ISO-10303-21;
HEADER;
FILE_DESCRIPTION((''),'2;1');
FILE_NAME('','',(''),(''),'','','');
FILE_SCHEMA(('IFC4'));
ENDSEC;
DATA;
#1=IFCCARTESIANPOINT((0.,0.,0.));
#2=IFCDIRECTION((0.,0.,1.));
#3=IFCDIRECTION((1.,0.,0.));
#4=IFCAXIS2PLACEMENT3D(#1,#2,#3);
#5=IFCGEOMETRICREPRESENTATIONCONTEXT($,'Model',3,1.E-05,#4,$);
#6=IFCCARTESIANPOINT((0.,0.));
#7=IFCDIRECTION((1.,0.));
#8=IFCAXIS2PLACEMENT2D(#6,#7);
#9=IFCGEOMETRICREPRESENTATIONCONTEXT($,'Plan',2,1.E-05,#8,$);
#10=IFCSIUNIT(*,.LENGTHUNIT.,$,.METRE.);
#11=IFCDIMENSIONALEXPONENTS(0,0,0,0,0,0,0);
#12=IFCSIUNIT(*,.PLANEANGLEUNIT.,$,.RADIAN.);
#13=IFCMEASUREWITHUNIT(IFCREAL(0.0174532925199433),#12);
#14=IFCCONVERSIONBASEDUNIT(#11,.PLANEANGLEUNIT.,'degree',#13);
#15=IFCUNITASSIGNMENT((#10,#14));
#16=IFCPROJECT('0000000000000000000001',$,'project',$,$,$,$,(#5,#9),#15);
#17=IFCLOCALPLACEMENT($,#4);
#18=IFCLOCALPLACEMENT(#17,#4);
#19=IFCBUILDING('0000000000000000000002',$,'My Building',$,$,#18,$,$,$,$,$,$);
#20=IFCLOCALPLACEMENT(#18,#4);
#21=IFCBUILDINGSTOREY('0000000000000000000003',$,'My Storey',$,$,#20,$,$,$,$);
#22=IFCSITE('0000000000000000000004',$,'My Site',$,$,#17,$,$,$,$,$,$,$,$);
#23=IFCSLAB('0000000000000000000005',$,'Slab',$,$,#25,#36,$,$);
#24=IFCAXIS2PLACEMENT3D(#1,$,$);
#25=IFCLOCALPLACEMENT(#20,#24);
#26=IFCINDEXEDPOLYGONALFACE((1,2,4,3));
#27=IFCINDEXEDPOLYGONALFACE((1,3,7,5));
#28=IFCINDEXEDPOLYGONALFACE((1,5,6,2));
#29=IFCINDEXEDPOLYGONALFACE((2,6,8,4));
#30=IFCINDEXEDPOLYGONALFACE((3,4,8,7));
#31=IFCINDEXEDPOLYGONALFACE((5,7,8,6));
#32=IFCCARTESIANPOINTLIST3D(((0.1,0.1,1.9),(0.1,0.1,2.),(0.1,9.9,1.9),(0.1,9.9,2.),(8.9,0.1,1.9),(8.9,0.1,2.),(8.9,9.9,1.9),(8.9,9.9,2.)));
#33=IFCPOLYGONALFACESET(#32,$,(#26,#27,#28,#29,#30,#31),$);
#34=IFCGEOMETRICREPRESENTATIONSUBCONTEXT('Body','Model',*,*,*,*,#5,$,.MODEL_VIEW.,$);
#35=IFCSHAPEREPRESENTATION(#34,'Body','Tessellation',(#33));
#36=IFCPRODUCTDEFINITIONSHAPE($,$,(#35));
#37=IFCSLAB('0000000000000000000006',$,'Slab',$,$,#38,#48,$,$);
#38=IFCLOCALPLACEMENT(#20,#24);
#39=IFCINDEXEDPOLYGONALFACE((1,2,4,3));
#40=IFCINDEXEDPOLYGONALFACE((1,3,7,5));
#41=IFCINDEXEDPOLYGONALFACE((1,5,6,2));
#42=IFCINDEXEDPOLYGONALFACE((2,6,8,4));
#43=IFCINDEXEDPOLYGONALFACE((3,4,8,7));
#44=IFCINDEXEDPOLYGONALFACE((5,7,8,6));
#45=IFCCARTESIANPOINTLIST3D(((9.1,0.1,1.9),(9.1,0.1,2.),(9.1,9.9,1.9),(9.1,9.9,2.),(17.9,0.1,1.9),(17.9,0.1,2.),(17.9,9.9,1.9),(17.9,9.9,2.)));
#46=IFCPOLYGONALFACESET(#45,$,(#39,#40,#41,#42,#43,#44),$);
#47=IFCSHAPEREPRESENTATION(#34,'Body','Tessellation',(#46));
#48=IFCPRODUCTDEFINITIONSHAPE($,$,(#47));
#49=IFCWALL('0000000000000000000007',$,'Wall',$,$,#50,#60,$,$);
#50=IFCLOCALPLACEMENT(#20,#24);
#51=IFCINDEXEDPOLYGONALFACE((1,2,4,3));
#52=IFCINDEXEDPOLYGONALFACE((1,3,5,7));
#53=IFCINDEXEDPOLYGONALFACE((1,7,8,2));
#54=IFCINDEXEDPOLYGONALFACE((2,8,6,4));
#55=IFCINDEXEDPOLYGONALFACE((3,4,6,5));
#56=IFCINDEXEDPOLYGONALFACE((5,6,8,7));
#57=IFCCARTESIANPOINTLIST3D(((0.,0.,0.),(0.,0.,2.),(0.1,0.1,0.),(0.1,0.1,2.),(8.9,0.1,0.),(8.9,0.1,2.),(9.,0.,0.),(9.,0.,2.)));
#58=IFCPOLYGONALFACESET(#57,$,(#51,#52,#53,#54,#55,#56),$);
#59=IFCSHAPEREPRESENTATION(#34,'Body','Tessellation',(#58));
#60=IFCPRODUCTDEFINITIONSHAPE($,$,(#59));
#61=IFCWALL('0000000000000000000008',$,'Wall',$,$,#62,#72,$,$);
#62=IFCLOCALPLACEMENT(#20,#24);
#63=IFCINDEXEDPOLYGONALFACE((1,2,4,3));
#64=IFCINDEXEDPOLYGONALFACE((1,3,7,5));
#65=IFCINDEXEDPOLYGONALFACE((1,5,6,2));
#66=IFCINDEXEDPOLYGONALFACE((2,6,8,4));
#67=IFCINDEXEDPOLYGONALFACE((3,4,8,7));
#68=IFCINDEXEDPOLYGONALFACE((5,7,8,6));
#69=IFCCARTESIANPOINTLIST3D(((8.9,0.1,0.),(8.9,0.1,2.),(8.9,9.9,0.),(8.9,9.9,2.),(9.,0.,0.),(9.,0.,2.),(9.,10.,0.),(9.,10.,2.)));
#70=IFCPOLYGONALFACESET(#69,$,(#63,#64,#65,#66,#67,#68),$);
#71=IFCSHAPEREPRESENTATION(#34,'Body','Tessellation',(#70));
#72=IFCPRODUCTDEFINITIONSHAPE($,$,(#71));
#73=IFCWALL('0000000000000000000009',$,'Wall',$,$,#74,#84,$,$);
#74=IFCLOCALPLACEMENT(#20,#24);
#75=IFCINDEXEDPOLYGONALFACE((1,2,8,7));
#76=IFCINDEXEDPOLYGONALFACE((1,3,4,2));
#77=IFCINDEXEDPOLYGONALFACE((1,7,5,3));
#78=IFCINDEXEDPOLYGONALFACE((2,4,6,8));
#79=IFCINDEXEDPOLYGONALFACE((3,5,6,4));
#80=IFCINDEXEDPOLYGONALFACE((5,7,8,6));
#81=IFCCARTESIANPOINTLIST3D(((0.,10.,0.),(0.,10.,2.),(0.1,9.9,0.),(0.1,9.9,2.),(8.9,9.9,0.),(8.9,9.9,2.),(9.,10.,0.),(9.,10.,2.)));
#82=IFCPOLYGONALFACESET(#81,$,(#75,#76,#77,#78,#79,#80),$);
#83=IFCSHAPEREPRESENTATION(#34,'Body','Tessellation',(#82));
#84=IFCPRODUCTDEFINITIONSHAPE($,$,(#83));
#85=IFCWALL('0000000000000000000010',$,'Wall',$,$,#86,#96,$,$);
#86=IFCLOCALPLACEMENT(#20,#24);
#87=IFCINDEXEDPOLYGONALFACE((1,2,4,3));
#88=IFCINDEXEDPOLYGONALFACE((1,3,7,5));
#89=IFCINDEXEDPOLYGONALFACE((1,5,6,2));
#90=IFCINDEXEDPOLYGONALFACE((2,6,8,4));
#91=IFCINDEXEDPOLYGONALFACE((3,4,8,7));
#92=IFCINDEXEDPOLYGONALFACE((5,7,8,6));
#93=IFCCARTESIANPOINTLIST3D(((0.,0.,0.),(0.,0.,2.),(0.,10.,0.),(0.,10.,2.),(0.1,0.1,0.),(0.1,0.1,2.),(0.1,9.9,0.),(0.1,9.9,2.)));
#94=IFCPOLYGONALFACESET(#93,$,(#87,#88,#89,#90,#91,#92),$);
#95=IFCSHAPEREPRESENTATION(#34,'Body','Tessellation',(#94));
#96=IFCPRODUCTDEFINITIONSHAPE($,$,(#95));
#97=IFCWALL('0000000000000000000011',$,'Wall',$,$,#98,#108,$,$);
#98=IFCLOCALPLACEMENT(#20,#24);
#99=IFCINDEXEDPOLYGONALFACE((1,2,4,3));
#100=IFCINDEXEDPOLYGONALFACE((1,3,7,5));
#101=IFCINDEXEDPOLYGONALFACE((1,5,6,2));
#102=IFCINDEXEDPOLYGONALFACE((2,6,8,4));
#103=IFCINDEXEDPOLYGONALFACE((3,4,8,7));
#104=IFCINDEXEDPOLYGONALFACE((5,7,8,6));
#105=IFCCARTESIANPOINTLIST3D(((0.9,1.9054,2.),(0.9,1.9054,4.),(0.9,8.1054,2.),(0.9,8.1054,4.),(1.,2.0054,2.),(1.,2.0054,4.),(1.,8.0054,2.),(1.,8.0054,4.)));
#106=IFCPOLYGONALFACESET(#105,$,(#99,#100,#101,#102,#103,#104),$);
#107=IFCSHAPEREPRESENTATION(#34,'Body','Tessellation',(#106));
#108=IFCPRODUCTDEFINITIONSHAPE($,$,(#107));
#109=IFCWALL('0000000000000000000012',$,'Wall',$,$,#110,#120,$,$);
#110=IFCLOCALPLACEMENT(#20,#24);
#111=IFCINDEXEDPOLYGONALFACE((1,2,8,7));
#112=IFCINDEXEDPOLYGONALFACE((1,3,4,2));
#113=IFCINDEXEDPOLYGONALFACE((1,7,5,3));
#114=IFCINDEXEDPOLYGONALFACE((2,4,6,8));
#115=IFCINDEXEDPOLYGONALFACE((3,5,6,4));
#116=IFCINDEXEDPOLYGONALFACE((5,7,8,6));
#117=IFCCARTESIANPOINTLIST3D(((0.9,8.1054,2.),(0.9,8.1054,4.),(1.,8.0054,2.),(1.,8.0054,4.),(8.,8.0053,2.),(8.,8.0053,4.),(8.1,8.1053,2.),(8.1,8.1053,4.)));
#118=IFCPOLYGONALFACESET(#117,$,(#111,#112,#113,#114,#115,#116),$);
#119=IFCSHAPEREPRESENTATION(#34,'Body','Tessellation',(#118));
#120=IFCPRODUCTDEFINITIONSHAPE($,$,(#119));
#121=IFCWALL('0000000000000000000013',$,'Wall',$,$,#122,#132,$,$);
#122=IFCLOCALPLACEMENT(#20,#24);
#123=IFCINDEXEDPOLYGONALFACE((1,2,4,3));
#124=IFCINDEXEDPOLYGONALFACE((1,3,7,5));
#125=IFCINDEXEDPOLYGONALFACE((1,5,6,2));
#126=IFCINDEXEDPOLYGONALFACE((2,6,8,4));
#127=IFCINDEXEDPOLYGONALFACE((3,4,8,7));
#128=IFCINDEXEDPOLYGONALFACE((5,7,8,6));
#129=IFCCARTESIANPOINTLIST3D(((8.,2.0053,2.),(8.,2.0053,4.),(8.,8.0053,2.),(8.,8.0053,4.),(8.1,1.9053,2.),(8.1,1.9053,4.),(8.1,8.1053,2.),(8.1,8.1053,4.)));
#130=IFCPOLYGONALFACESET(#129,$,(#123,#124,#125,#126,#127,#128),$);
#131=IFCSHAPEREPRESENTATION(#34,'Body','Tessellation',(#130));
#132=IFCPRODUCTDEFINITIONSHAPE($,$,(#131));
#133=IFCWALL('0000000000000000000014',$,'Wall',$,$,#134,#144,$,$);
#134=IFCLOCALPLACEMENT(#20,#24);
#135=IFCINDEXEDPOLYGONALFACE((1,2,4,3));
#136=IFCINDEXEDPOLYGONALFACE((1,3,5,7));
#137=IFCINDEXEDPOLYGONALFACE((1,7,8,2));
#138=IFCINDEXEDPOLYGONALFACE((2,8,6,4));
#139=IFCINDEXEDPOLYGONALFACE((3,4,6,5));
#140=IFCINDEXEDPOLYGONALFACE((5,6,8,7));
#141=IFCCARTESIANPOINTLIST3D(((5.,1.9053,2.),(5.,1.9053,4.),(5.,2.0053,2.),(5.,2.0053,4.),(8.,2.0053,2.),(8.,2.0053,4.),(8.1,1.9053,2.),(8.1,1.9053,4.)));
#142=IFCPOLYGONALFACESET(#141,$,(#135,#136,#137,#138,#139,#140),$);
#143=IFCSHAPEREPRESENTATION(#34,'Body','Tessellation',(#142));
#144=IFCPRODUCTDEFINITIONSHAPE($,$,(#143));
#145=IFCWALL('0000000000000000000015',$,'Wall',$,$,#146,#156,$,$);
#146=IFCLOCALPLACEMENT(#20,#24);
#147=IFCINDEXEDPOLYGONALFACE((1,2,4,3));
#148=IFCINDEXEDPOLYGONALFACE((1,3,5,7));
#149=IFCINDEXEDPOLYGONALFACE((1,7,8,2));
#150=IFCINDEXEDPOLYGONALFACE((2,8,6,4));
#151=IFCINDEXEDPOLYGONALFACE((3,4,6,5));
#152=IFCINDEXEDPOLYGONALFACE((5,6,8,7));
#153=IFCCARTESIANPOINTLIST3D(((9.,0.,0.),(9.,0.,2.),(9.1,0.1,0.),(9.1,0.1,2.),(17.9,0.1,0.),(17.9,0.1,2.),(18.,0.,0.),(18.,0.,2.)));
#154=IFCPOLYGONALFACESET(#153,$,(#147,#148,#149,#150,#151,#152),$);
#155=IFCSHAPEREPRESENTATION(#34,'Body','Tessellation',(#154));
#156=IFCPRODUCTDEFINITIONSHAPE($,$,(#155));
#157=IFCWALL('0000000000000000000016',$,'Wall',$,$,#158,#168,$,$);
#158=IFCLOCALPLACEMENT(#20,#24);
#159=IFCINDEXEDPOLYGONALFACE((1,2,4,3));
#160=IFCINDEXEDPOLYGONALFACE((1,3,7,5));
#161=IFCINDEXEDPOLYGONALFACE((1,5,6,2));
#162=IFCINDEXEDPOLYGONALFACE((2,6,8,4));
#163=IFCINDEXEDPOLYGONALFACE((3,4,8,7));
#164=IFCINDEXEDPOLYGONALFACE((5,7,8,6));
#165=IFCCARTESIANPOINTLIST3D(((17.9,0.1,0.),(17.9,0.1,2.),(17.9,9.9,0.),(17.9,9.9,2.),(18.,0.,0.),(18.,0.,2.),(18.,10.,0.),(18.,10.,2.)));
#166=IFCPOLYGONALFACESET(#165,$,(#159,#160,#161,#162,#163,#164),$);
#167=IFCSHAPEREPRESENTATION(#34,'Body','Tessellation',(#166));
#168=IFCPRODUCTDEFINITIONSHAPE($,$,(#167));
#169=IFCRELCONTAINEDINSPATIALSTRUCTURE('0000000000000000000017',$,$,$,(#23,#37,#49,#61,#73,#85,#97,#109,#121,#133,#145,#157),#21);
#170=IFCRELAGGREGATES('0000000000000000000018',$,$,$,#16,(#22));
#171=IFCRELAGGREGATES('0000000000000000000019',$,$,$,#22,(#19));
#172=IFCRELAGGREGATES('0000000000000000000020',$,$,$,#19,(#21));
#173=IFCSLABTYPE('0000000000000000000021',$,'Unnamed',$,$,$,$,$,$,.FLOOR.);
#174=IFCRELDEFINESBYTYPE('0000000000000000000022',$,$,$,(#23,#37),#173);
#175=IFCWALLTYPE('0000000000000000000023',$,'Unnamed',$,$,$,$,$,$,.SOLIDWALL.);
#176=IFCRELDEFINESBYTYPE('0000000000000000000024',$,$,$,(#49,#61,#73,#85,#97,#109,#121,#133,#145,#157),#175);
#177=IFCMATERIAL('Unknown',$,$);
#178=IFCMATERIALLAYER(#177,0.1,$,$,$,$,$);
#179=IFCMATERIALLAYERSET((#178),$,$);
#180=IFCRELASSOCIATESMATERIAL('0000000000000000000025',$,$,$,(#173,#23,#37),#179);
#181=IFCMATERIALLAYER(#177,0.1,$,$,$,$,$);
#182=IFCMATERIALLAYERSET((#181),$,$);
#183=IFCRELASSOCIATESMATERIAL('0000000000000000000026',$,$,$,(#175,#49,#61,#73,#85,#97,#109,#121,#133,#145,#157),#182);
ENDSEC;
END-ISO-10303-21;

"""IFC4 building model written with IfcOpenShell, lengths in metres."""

from ifc_helpers import new_model, entity, si_unit, converted_unit, frame, origin_with_axes, origin_2d_with_axis, place, context, subcontext, project, spatial, indexed_curve, outline, extrude, clip, halfspace, material, layer, layer_set, layer_usage, type_object, element, save


model = new_model("IFC4")

# Units and contexts
model_context = context("Model", 3, precision=1e-05, world=origin_with_axes())
plan_context = context("Plan", 2, precision=1e-05, world=origin_2d_with_axis())
body_context_1 = subcontext(model_context, "Body", "Model", "MODEL_VIEW")
ifc_project = project(units=[si_unit("LENGTHUNIT", "METRE"), converted_unit("PLANEANGLEUNIT", "degree", entity("IfcReal", 0.0174532925199433), si_unit("PLANEANGLEUNIT", "RADIAN"), dimensions=[0, 0, 0, 0, 0, 0, 0])], contexts=[model_context, plan_context])

# Site, building, storey
site_placement = place(None, origin_with_axes())
site = spatial("IfcSite", under=ifc_project, at=site_placement, Name="My Site")
building_placement = place(site_placement, origin_with_axes())
building = spatial("IfcBuilding", under=site, at=building_placement, Name="My Building")
storey_placement = place(building_placement, origin_with_axes())
storey = spatial("IfcBuildingStorey", under=building, at=storey_placement, Name="My Storey")

# Slabs
ifc_material = material(Name="Unknown")
ifc_layer_1 = layer(ifc_material, 0.1)
ifc_layer_set_1 = layer_set([ifc_layer_1])
ifc_layer_usage_1 = layer_usage(ifc_layer_set_1, "AXIS3", "POSITIVE", -0.1)
slab_type = type_object("IfcSlabType", Name="Unnamed", PredefinedType="FLOOR", material=ifc_layer_set_1)
slab_1_placement = place(storey_placement, frame((0.1, 9.9, 2.0), z_axis=(0.0, 0.0, 1.0), x_axis=(1.0, 0.0, 0.0)))
element("IfcSlab", 1, at=slab_1_placement, inside=storey, type_object=slab_type, material=ifc_layer_usage_1, Name="Slab", context=body_context_1, shape_type="SweptSolid", body=[
    extrude(outline(indexed_curve([(0.0, 0.0), (8.8, 0.0), (8.8, -9.8), (0.0, -9.8), (0.0, 0.0)])), frame((0.0, 0.0, -0.1), z_axis=(0.0, 0.0, 1.0), x_axis=(1.0, 0.0, 0.0)), (0.0, 0.0, 1.0), 0.1),
])
ifc_layer_usage_2 = layer_usage(ifc_layer_set_1, "AXIS3", "POSITIVE", -0.1)
slab_2_placement = place(storey_placement, frame((9.1, 0.1, 2.0), z_axis=(0.0, 0.0, 1.0), x_axis=(1.0, 0.0, 0.0)))
element("IfcSlab", 2, at=slab_2_placement, inside=storey, type_object=slab_type, material=ifc_layer_usage_2, Name="Slab", context=body_context_1, shape_type="SweptSolid", body=[
    extrude(outline(indexed_curve([(0.0, 0.0), (8.8, 0.0), (8.8, 9.8), (0.0, 9.8), (0.0, 0.0)])), frame((0.0, 0.0, -0.1), z_axis=(0.0, 0.0, 1.0), x_axis=(1.0, 0.0, 0.0)), (0.0, 0.0, 1.0), 0.1),
])

# Walls
ifc_layer_2 = layer(ifc_material, 0.1)
ifc_layer_set_2 = layer_set([ifc_layer_2])
ifc_layer_usage_3 = layer_usage(ifc_layer_set_2, "AXIS2", "POSITIVE", 0.0)
wall_type = type_object("IfcWallType", Name="Unnamed", PredefinedType="SOLIDWALL", material=ifc_layer_set_2)
wall_1_placement = place(storey_placement, origin_with_axes())
element("IfcWall", 3, at=wall_1_placement, inside=storey, type_object=wall_type, material=ifc_layer_usage_3, Name="Wall", context=body_context_1, shape_type="Clipping", body=[
    clip(clip(extrude(outline(indexed_curve([(0.0, 0.0), (0.0, 0.1), (9.0, 0.1), (9.0, 0.0), (0.0, 0.0)], self_intersect=False)), origin_with_axes(), (0.0, 0.0, 1.0), 2.0), halfspace(frame((9.0, 0.0, 0.0), z_axis=(0.707105, 0.707108, 0.0), x_axis=(0.707108, -0.707105, 0.0)), False)), halfspace(frame((0.0, 0.0, 0.0), z_axis=(-0.707107, 0.707107, 0.0), x_axis=(0.707107, 0.707107, 0.0)), False)),
])
ifc_layer_usage_4 = layer_usage(ifc_layer_set_2, "AXIS2", "POSITIVE", 0.0)
wall_2_placement = place(storey_placement, frame((9.0, 0.0, 0.0), z_axis=(0.0, 0.0, 1.0), x_axis=(0.0, 1.0, 0.0)))
element("IfcWall", 4, at=wall_2_placement, inside=storey, type_object=wall_type, material=ifc_layer_usage_4, Name="Wall", context=body_context_1, shape_type="Clipping", body=[
    clip(clip(extrude(outline(indexed_curve([(0.0, 0.0), (0.0, 0.1), (10.0, 0.1), (10.0, 0.0), (0.0, 0.0)], self_intersect=False)), origin_with_axes(), (0.0, 0.0, 1.0), 2.0), halfspace(frame((10.0, 0.0, 0.0), z_axis=(0.707107, 0.707107, 0.0), x_axis=(0.707107, -0.707107, 0.0)), False)), halfspace(frame((0.0, 0.0, 0.0), z_axis=(-0.707108, 0.707105, 0.0), x_axis=(0.707105, 0.707108, 0.0)), False)),
])
ifc_layer_usage_5 = layer_usage(ifc_layer_set_2, "AXIS2", "POSITIVE", 0.0)
wall_3_placement = place(storey_placement, frame((9.0, 10.0, 0.0), z_axis=(0.0, 0.0, 1.0), x_axis=(-1.0, 0.0, 0.0)))
element("IfcWall", 5, at=wall_3_placement, inside=storey, type_object=wall_type, material=ifc_layer_usage_5, Name="Wall", context=body_context_1, shape_type="Clipping", body=[
    clip(clip(extrude(outline(indexed_curve([(0.0, 0.0), (0.0, 0.1), (9.0, 0.1), (9.0, 0.0), (0.0, 0.0)], self_intersect=False)), origin_with_axes(), (0.0, 0.0, 1.0), 2.0), halfspace(frame((9.0, 0.0, 0.0), z_axis=(0.707108, 0.707106, 0.0), x_axis=(0.707106, -0.707108, 0.0)), False)), halfspace(frame((0.0, 0.0, 0.0), z_axis=(-0.707107, 0.707107, 0.0), x_axis=(0.707107, 0.707107, 0.0)), False)),
])
ifc_layer_usage_6 = layer_usage(ifc_layer_set_2, "AXIS2", "POSITIVE", 0.0)
wall_4_placement = place(storey_placement, frame((0.0, 10.0, 0.0), z_axis=(0.0, 0.0, 1.0), x_axis=(0.0, -1.0, 0.0)))
element("IfcWall", 6, at=wall_4_placement, inside=storey, type_object=wall_type, material=ifc_layer_usage_6, Name="Wall", context=body_context_1, shape_type="Clipping", body=[
    clip(clip(extrude(outline(indexed_curve([(0.0, 0.0), (0.0, 0.1), (10.0, 0.1), (10.0, 0.0), (0.0, 0.0)], self_intersect=False)), origin_with_axes(), (0.0, 0.0, 1.0), 2.0), halfspace(frame((10.0, 0.0, 0.0), z_axis=(0.707107, 0.707107, 0.0), x_axis=(0.707107, -0.707107, 0.0)), False)), halfspace(frame((0.0, 0.0, 0.0), z_axis=(-0.707105, 0.707108, 0.0), x_axis=(0.707108, 0.707105, 0.0)), False)),
])
ifc_layer_usage_7 = layer_usage(ifc_layer_set_2, "AXIS2", "POSITIVE", 0.0)
wall_5_placement = place(storey_placement, frame((1.0, 1.9054, 2.0), z_axis=(0.0, 0.0, 1.0), x_axis=(0.0, 1.0, 0.0)))
element("IfcWall", 7, at=wall_5_placement, inside=storey, type_object=wall_type, material=ifc_layer_usage_7, Name="Wall", context=body_context_1, shape_type="Clipping", body=[
    clip(clip(extrude(outline(indexed_curve([(0.0, 0.0), (0.0, 0.1), (6.2, 0.1), (6.2, 0.0), (0.0, 0.0)], self_intersect=False)), origin_with_axes(), (0.0, 0.0, 1.0), 2.0), halfspace(frame((6.1, 0.0, 0.0), z_axis=(0.707107, -0.707107, 0.0), x_axis=(-0.707107, -0.707107, 0.0)), False)), halfspace(frame((0.1, 0.0, 0.0), z_axis=(-0.707107, -0.707106, 0.0), x_axis=(-0.707106, 0.707107, 0.0)), False)),
])
ifc_layer_usage_8 = layer_usage(ifc_layer_set_2, "AXIS2", "POSITIVE", 0.0)
wall_6_placement = place(storey_placement, frame((0.9, 8.0054, 2.0), z_axis=(0.0, 0.0, 1.0), x_axis=(1.0, 0.0, 0.0)))
element("IfcWall", 8, at=wall_6_placement, inside=storey, type_object=wall_type, material=ifc_layer_usage_8, Name="Wall", context=body_context_1, shape_type="Clipping", body=[
    clip(clip(extrude(outline(indexed_curve([(0.0, 0.0), (0.0, 0.1), (7.2, 0.1), (7.2, 0.0), (0.0, 0.0)], self_intersect=False)), origin_with_axes(), (0.0, 0.0, 1.0), 2.0), halfspace(frame((7.1, 0.0, 0.0), z_axis=(0.707102, -0.707111, 0.0), x_axis=(-0.707111, -0.707102, 0.0)), False)), halfspace(frame((0.1, 0.0, 0.0), z_axis=(-0.707107, -0.707107, 0.0), x_axis=(-0.707107, 0.707107, 0.0)), False)),
])
ifc_layer_usage_9 = layer_usage(ifc_layer_set_2, "AXIS2", "POSITIVE", 0.0)
wall_7_placement = place(storey_placement, frame((8.0, 8.1053, 2.0), z_axis=(0.0, 0.0, 1.0), x_axis=(0.0, -1.0, 0.0)))
element("IfcWall", 9, at=wall_7_placement, inside=storey, type_object=wall_type, material=ifc_layer_usage_9, Name="Wall", context=body_context_1, shape_type="Clipping", body=[
    clip(clip(extrude(outline(indexed_curve([(0.0, 0.0), (0.0, 0.1), (6.2, 0.1), (6.2, 0.0), (0.0, 0.0)], self_intersect=False)), origin_with_axes(), (0.0, 0.0, 1.0), 2.0), halfspace(frame((6.1, 0.0, 0.0), z_axis=(0.70711, -0.707103, 0.0), x_axis=(-0.707103, -0.70711, 0.0)), False)), halfspace(frame((0.1, 0.0, 0.0), z_axis=(-0.707108, -0.707105, 0.0), x_axis=(-0.707105, 0.707108, 0.0)), False)),
])
ifc_layer_usage_10 = layer_usage(ifc_layer_set_2, "AXIS2", "POSITIVE", 0.0)
wall_8_placement = place(storey_placement, frame((8.1, 2.0053, 2.0), z_axis=(0.0, 0.0, 1.0), x_axis=(-1.0, 0.0, 0.0)))
element("IfcWall", 10, at=wall_8_placement, inside=storey, type_object=wall_type, material=ifc_layer_usage_10, Name="Wall", context=body_context_1, shape_type="Clipping", body=[
    clip(extrude(outline(indexed_curve([(0.0, 0.0), (0.0, 0.1), (3.1, 0.1), (3.1, 0.0), (0.0, 0.0)], self_intersect=False)), origin_with_axes(), (0.0, 0.0, 1.0), 2.0), halfspace(frame((0.1, 0.0, 0.0), z_axis=(-0.707103, -0.70711, 0.0), x_axis=(-0.70711, 0.707103, 0.0)), False)),
])
ifc_layer_usage_11 = layer_usage(ifc_layer_set_2, "AXIS2", "POSITIVE", 0.0)
wall_9_placement = place(storey_placement, frame((9.0, 0.0, 0.0), z_axis=(0.0, 0.0, 1.0), x_axis=(1.0, 0.0, 0.0)))
element("IfcWall", 11, at=wall_9_placement, inside=storey, type_object=wall_type, material=ifc_layer_usage_11, Name="Wall", context=body_context_1, shape_type="Clipping", body=[
    clip(clip(extrude(outline(indexed_curve([(0.0, 0.0), (0.0, 0.1), (9.0, 0.1), (9.0, 0.0), (0.0, 0.0)], self_intersect=False)), origin_with_axes(), (0.0, 0.0, 1.0), 2.0), halfspace(frame((9.0, 0.0, 0.0), z_axis=(0.707105, 0.707108, 0.0), x_axis=(0.707108, -0.707105, 0.0)), False)), halfspace(frame((0.0, 0.0, 0.0), z_axis=(-0.707105, 0.707108, 0.0), x_axis=(0.707108, 0.707105, 0.0)), False)),
])
ifc_layer_usage_12 = layer_usage(ifc_layer_set_2, "AXIS2", "POSITIVE", 0.0)
wall_10_placement = place(storey_placement, frame((18.0, 0.0, 0.0), z_axis=(0.0, 0.0, 1.0), x_axis=(0.0, 1.0, 0.0)))
element("IfcWall", 12, at=wall_10_placement, inside=storey, type_object=wall_type, material=ifc_layer_usage_12, Name="Wall", context=body_context_1, shape_type="Clipping", body=[
    clip(clip(extrude(outline(indexed_curve([(0.0, 0.0), (0.0, 0.1), (10.0, 0.1), (10.0, 0.0), (0.0, 0.0)], self_intersect=False)), origin_with_axes(), (0.0, 0.0, 1.0), 2.0), halfspace(frame((10.0, 0.0, 0.0), z_axis=(0.707107, 0.707107, 0.0), x_axis=(0.707107, -0.707107, 0.0)), False)), halfspace(frame((0.0, 0.0, 0.0), z_axis=(-0.707108, 0.707105, 0.0), x_axis=(0.707105, 0.707108, 0.0)), False)),
])

save(model, "model.ifc")
